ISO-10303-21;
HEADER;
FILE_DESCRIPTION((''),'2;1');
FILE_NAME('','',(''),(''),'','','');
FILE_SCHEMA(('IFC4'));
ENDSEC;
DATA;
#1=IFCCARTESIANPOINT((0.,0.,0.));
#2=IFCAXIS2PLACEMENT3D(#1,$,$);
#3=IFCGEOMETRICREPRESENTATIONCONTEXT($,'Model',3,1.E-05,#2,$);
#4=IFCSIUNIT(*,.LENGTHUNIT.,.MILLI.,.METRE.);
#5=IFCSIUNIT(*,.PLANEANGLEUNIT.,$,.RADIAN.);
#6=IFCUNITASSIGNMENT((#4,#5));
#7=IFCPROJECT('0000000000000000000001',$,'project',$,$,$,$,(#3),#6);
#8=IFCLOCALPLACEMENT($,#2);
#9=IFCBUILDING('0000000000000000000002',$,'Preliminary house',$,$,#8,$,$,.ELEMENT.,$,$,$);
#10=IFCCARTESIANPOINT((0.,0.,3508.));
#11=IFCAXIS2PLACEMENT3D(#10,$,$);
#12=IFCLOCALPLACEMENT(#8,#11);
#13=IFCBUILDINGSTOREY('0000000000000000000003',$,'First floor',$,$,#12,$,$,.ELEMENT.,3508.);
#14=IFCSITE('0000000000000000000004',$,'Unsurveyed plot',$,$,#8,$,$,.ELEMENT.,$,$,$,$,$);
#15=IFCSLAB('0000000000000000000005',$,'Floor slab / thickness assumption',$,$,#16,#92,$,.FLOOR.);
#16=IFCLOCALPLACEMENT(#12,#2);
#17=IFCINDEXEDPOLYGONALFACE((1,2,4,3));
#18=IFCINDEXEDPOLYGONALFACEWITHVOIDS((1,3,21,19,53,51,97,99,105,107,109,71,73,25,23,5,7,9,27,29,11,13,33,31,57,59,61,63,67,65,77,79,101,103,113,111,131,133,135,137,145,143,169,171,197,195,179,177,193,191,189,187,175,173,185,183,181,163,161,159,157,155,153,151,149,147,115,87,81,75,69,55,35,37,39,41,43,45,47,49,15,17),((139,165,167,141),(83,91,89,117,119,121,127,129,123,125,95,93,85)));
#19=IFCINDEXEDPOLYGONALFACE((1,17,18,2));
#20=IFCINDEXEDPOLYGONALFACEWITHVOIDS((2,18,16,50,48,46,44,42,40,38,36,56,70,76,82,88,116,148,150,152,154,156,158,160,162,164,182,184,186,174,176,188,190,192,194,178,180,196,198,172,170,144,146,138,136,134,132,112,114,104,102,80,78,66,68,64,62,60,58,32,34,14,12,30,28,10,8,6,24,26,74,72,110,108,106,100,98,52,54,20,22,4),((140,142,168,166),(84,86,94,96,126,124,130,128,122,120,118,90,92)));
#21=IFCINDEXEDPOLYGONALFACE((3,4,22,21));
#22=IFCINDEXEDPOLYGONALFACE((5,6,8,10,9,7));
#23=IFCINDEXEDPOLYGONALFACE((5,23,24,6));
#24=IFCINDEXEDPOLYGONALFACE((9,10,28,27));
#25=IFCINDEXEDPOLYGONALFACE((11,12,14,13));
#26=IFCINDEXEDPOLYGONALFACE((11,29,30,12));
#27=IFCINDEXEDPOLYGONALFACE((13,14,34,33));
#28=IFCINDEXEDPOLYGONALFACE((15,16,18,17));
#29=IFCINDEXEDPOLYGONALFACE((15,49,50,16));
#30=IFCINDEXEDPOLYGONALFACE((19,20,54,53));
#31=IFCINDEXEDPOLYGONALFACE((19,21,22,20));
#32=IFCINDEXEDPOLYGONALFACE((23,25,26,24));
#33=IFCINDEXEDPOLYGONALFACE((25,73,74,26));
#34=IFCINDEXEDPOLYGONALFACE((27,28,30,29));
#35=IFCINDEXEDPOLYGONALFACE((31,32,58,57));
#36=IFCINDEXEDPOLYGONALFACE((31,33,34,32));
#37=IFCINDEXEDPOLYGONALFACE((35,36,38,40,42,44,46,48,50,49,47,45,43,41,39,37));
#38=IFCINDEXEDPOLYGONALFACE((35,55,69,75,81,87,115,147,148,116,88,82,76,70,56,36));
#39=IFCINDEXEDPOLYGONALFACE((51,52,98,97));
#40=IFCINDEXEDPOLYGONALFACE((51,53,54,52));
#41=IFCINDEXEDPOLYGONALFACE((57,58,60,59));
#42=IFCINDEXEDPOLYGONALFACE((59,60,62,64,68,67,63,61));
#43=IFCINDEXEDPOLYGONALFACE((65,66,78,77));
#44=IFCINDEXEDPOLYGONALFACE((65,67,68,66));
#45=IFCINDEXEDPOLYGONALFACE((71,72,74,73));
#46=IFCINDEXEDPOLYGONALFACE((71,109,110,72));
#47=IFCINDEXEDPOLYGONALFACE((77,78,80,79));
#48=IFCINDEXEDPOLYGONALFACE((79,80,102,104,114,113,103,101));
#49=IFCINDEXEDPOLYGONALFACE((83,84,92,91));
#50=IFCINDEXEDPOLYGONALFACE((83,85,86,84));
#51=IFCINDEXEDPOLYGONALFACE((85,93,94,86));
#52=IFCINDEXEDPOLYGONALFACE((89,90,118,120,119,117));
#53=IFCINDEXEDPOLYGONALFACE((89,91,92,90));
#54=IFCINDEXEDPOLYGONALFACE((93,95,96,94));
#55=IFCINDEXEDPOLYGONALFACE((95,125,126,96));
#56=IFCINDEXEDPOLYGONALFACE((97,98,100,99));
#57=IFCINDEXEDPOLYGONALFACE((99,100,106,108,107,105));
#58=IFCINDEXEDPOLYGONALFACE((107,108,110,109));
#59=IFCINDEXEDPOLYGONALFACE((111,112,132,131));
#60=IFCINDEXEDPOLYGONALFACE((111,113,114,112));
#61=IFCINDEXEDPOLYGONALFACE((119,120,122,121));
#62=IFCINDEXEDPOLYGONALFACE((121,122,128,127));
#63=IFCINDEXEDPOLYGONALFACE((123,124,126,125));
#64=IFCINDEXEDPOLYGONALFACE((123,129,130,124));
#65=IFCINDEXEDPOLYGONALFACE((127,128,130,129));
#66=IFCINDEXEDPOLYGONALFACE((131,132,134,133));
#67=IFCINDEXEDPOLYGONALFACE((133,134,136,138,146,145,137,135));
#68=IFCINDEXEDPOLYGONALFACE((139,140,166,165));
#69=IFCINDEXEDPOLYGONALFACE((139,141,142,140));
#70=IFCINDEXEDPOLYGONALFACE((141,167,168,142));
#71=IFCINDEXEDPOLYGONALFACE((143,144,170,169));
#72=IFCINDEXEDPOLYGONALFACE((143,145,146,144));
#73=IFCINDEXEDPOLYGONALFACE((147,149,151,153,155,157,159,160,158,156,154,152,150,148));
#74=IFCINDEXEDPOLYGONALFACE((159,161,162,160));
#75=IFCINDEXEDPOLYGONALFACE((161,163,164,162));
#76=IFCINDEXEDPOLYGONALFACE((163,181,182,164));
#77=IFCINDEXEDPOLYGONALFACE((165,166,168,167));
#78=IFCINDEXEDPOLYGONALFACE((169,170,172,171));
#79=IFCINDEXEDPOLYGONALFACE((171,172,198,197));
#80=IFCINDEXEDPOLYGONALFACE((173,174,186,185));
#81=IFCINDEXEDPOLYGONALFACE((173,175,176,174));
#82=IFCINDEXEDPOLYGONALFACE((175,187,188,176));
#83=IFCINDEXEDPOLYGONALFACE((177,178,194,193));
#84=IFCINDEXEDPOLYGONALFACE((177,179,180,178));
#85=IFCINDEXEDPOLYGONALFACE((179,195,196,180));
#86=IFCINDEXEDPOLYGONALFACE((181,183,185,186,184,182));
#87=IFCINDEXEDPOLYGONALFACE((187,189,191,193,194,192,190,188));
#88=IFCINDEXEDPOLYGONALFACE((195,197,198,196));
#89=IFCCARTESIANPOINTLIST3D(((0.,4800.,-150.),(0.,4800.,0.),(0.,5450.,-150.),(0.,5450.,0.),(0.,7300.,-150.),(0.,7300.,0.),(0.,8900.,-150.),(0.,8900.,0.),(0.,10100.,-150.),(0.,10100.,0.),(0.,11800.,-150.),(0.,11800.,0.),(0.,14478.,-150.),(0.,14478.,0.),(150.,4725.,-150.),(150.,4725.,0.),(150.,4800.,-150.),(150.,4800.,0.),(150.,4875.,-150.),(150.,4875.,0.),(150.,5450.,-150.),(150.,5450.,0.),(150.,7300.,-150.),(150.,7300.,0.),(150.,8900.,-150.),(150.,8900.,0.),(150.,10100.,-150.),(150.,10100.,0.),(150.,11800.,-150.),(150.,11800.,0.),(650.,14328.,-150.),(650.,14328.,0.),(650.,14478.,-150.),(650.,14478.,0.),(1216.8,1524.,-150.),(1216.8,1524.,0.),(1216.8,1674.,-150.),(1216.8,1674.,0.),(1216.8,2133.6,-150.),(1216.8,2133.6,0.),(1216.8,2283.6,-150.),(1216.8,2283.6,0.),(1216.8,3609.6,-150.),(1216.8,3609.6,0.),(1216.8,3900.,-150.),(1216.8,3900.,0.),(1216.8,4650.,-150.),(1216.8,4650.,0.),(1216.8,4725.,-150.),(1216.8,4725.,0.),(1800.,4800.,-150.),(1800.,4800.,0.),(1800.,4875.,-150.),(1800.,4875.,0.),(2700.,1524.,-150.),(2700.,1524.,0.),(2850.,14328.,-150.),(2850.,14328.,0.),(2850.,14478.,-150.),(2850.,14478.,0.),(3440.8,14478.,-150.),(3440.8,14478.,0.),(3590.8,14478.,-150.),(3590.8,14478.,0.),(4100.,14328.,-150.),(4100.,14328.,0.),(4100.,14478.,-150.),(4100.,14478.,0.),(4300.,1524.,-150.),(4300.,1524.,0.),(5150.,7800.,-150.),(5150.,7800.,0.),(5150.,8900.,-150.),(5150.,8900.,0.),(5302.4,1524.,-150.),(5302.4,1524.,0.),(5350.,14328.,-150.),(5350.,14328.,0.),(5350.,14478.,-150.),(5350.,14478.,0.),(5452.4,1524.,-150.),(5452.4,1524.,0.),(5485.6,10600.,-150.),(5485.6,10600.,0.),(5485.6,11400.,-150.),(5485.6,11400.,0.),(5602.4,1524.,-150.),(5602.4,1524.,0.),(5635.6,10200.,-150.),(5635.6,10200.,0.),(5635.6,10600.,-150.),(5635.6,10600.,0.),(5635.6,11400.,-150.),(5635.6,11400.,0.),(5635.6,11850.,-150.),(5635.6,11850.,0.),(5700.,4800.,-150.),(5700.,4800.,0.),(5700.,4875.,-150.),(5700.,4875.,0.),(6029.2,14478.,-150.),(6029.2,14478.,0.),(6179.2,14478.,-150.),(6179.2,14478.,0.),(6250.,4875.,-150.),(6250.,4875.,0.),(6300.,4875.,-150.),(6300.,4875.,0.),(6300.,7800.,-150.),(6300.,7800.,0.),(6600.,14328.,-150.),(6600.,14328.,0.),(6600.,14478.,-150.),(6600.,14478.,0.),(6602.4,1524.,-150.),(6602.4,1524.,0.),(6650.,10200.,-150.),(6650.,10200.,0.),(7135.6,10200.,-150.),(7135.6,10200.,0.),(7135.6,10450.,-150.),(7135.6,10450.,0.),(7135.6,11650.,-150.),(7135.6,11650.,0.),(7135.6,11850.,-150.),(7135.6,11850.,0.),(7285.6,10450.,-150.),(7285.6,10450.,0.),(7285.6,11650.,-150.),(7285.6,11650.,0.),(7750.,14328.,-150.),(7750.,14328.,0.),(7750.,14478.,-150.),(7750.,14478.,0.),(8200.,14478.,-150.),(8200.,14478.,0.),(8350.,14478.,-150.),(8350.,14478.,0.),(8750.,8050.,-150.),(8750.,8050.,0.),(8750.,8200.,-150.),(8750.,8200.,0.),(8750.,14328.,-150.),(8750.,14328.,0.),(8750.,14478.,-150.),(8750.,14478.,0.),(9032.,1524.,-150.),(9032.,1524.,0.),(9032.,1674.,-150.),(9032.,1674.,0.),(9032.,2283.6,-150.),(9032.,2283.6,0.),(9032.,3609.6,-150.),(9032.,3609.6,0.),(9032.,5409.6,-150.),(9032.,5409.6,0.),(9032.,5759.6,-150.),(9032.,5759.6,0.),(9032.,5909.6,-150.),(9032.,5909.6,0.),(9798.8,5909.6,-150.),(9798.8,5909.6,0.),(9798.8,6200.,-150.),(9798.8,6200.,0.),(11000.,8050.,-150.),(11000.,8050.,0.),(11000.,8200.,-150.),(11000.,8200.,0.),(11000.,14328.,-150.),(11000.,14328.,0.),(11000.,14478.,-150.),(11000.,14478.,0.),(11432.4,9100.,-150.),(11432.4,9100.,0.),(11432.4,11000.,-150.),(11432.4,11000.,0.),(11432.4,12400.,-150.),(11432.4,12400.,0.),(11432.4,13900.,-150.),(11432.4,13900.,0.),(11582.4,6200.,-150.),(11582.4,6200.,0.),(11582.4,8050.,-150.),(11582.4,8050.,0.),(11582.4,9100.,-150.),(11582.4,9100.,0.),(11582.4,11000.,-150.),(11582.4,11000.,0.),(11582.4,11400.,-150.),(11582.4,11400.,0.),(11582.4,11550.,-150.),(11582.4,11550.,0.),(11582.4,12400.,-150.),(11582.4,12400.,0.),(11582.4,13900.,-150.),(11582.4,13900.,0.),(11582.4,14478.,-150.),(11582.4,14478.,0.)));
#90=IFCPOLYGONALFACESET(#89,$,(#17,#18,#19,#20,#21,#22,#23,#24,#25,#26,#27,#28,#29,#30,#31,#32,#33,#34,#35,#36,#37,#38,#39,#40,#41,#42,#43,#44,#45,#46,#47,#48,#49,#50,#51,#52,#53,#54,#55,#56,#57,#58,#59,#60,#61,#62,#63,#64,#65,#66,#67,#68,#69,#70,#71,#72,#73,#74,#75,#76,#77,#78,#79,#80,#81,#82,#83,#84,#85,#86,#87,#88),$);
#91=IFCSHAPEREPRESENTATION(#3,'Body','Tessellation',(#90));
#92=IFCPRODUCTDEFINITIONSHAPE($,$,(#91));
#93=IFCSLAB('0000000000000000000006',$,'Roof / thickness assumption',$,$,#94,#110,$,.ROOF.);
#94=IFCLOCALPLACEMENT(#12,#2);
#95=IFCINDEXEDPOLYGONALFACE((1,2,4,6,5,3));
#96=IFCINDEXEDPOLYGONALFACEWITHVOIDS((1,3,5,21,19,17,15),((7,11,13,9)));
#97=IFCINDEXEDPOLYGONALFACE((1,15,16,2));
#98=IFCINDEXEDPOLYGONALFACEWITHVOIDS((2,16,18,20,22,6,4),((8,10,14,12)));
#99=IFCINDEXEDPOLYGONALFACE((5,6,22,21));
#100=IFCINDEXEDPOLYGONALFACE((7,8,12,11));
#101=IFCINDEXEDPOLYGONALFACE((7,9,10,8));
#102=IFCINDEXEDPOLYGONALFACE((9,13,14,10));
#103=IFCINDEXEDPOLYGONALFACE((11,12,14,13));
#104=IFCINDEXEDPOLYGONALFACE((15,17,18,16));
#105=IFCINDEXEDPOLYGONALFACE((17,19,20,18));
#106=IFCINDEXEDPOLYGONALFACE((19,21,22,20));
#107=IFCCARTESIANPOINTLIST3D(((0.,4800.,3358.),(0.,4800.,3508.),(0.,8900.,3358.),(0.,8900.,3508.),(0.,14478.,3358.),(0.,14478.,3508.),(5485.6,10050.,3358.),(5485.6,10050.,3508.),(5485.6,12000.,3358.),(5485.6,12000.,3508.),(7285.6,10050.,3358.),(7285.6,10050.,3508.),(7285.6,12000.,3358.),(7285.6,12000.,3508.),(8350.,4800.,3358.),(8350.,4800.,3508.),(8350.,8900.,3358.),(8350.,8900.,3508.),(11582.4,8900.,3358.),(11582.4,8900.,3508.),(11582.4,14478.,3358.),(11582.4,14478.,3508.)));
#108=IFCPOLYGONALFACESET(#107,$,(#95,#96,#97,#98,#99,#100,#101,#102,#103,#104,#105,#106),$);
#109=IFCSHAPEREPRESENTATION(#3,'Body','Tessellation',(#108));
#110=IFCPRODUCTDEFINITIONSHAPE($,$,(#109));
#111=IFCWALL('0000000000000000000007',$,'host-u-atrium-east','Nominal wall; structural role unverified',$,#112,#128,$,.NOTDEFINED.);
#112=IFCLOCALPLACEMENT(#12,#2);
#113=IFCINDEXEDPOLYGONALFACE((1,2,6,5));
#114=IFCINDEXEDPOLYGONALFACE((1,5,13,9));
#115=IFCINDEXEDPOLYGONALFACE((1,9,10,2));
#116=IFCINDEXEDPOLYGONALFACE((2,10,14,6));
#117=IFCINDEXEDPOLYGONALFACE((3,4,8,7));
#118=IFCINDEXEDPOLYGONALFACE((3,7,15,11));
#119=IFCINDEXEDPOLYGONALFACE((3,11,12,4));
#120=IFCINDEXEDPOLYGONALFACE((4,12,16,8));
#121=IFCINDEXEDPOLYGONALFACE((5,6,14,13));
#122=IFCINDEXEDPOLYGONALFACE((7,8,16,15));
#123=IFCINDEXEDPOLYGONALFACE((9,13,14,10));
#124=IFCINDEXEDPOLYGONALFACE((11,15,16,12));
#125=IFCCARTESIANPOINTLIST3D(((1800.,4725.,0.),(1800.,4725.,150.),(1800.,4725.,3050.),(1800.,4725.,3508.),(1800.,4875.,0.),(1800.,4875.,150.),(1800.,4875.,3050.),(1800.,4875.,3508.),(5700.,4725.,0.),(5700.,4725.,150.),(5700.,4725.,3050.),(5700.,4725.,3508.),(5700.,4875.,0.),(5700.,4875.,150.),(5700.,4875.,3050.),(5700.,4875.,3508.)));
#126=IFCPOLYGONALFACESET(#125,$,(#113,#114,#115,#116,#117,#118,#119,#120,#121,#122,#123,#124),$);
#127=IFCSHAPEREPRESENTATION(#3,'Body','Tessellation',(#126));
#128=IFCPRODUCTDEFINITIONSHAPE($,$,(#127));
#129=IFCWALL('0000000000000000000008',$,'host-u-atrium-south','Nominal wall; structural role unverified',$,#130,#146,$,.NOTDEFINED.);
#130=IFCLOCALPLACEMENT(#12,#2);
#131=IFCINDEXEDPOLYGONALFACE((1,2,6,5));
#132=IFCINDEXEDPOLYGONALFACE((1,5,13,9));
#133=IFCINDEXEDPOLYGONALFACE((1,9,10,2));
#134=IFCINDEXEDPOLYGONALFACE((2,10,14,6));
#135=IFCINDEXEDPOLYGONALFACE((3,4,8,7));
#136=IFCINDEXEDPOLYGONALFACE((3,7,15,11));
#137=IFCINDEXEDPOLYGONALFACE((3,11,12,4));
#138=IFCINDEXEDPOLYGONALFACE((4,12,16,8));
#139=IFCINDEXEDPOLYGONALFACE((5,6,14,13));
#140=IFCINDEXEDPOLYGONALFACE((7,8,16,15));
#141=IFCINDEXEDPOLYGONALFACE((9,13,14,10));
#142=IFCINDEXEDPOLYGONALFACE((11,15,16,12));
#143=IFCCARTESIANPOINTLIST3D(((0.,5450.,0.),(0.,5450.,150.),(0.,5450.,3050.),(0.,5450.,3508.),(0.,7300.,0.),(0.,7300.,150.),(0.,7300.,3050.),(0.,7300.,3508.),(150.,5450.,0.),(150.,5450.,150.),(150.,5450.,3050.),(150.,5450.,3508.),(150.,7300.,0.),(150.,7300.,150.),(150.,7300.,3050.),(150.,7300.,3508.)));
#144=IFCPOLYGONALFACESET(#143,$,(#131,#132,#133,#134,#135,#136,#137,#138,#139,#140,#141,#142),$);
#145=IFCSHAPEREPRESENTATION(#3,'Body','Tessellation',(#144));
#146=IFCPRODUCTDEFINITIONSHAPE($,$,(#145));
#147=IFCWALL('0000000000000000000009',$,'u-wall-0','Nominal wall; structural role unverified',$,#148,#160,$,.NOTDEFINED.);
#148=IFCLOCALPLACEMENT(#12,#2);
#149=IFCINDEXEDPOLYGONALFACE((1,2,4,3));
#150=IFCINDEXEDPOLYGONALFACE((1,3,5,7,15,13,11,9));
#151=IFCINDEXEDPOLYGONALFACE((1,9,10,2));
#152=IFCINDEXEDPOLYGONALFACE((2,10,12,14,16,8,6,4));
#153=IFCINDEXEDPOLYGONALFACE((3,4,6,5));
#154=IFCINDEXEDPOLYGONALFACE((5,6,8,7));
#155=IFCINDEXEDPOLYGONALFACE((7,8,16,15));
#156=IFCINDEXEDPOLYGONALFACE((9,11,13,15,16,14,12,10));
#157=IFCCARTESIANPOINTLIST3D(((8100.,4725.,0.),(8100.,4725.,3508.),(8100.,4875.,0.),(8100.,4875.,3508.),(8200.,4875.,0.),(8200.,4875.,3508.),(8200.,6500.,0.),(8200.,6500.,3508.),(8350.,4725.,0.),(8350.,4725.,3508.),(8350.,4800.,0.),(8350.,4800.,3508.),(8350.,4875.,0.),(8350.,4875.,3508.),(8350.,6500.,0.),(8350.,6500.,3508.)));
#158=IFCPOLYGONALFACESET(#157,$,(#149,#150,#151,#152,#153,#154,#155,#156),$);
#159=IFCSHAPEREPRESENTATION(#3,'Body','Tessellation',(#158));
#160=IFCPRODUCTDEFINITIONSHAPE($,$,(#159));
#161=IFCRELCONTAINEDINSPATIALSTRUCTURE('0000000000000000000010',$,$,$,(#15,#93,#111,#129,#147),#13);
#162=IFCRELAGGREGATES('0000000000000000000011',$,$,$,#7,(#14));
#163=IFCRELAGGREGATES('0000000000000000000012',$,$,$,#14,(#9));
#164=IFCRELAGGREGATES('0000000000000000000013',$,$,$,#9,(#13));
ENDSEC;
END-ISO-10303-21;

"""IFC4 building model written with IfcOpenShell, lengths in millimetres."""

from ifc_helpers import new_model, si_unit, frame, origin, place, context, project, spatial, polyline, outline, extrude, element, save


model = new_model("IFC4")

# Units and contexts
model_context = context("Model", 3, precision=1e-05, world=origin())
ifc_project = project(units=[si_unit("LENGTHUNIT", "METRE", prefix="MILLI"), si_unit("PLANEANGLEUNIT", "RADIAN")], contexts=[model_context])

# Site, building, storey
placement_1 = place(None, origin())
site = spatial("IfcSite", under=ifc_project, at=placement_1, Name="Unsurveyed plot", CompositionType="ELEMENT")
building = spatial("IfcBuilding", under=site, at=placement_1, Name="Preliminary house", CompositionType="ELEMENT")
placement_2 = place(placement_1, frame((0.0, 0.0, 3508.0)))
storey = spatial("IfcBuildingStorey", under=building, at=placement_2, Name="First floor", CompositionType="ELEMENT", Elevation=3508.0)

# Slabs
element("IfcSlab", 1, at=placement_2, inside=storey, Name="Floor slab / thickness assumption", PredefinedType="FLOOR", context=model_context, shape_type="SweptSolid", body=[
    extrude(outline(polyline([(6300.0, 4875.0), (6300.0, 7800.0), (5150.0, 7800.0), (5150.0, 8900.0), (150.0, 8900.0), (150.0, 7300.0), (0.0, 7300.0), (0.0, 8900.0), (0.0, 10100.0), (150.0, 10100.0), (150.0, 11800.0), (0.0, 11800.0), (0.0, 14478.0), (650.0, 14478.0), (650.0, 14328.0), (2850.0, 14328.0), (2850.0, 14478.0), (3440.8, 14478.0), (3590.8, 14478.0), (4100.0, 14478.0), (4100.0, 14328.0), (5350.0, 14328.0), (5350.0, 14478.0), (6029.2, 14478.0), (6179.2, 14478.0), (6600.0, 14478.0), (6600.0, 14328.0), (7750.0, 14328.0), (7750.0, 14478.0), (8200.0, 14478.0), (8350.0, 14478.0), (8750.0, 14478.0), (8750.0, 14328.0), (11000.0, 14328.0), (11000.0, 14478.0), (11582.4, 14478.0), (11582.4, 13900.0), (11432.4, 13900.0), (11432.4, 12400.0), (11582.4, 12400.0), (11582.4, 11550.0), (11582.4, 11400.0), (11582.4, 11000.0), (11432.4, 11000.0), (11432.4, 9100.0), (11582.4, 9100.0), (11582.4, 8050.0), (11582.4, 6200.0), (9798.8, 6200.0), (9798.8, 5909.6), (9032.0, 5909.6), (9032.0, 5759.6), (9032.0, 5409.6), (9032.0, 3609.6), (9032.0, 2283.6), (9032.0, 1674.0), (9032.0, 1524.0), (6602.4, 1524.0), (5602.4, 1524.0), (5452.4, 1524.0), (5302.4, 1524.0), (4300.0, 1524.0), (2700.0, 1524.0), (1216.8, 1524.0), (1216.8, 1674.0), (1216.8, 2133.6), (1216.8, 2283.6), (1216.8, 3609.6), (1216.8, 3900.0), (1216.8, 4650.0), (1216.8, 4725.0), (150.0, 4725.0), (150.0, 4800.0), (0.0, 4800.0), (0.0, 5450.0), (150.0, 5450.0), (150.0, 4875.0), (1800.0, 4875.0), (1800.0, 4800.0), (5700.0, 4800.0), (5700.0, 4875.0), (6250.0, 4875.0), (6300.0, 4875.0)]), holes=[polyline([(11000.0, 8050.0), (11000.0, 8200.0), (8750.0, 8200.0), (8750.0, 8050.0), (11000.0, 8050.0)]), polyline([(7135.6, 11650.0), (7135.6, 11850.0), (5635.6, 11850.0), (5635.6, 11400.0), (5485.6, 11400.0), (5485.6, 10600.0), (5635.6, 10600.0), (5635.6, 10200.0), (6650.0, 10200.0), (7135.6, 10200.0), (7135.6, 10450.0), (7285.6, 10450.0), (7285.6, 11650.0), (7135.6, 11650.0)])]), frame((0.0, 0.0, -150.0)), (0.0, 0.0, 1.0), 150.0),
])
element("IfcSlab", 2, at=placement_2, inside=storey, Name="Roof / thickness assumption", PredefinedType="ROOF", context=model_context, shape_type="SweptSolid", body=[
    extrude(outline(polyline([(0.0, 4800.0), (0.0, 8900.0), (0.0, 14478.0), (11582.4, 14478.0), (11582.4, 8900.0), (8350.0, 8900.0), (8350.0, 4800.0), (0.0, 4800.0)]), holes=[polyline([(7285.6, 12000.0), (5485.6, 12000.0), (5485.6, 10050.0), (7285.6, 10050.0), (7285.6, 12000.0)])]), frame((0.0, 0.0, 3358.0)), (0.0, 0.0, 1.0), 150.0),
])

# Walls, openings
wall_1 = element("IfcWall", 3, at=placement_2, inside=storey, Name="host-u-atrium-east", Description="Nominal wall; structural role unverified", PredefinedType="NOTDEFINED", context=model_context, shape_type="SweptSolid", body=[
    extrude(outline(polyline([(5700.0, 4875.0), (5700.0, 4725.0), (1800.0, 4725.0), (1800.0, 4875.0), (5700.0, 4875.0)])), origin(), (0.0, 0.0, 1.0), 3508.0),
])
element("IfcOpeningElement", 4, at=placement_2, cuts=wall_1, PredefinedType="OPENING", context=model_context, shape_type="SweptSolid", body=[
    extrude(outline(polyline([(1800.0, 4350.0), (5700.0, 4350.0), (5700.0, 5250.0), (1800.0, 5250.0), (1800.0, 4350.0)])), frame((0.0, 0.0, 150.0)), (0.0, 0.0, 1.0), 2900.0),
])
wall_2 = element("IfcWall", 5, at=placement_2, inside=storey, Name="host-u-atrium-south", Description="Nominal wall; structural role unverified", PredefinedType="NOTDEFINED", context=model_context, shape_type="SweptSolid", body=[
    extrude(outline(polyline([(0.0, 7300.0), (150.0, 7300.0), (150.0, 5450.0), (0.0, 5450.0), (0.0, 7300.0)])), origin(), (0.0, 0.0, 1.0), 3508.0),
])
element("IfcOpeningElement", 6, at=placement_2, cuts=wall_2, PredefinedType="OPENING", context=model_context, shape_type="SweptSolid", body=[
    extrude(outline(polyline([(525.0, 5450.0), (525.0, 7300.0), (-375.0, 7300.0), (-375.0, 5450.0), (525.0, 5450.0)])), frame((0.0, 0.0, 150.0)), (0.0, 0.0, 1.0), 2900.0),
])

# Wall
element("IfcWall", 7, at=placement_2, inside=storey, Name="u-wall-0", Description="Nominal wall; structural role unverified", PredefinedType="NOTDEFINED", context=model_context, shape_type="SweptSolid", body=[
    extrude(outline(polyline([(8350.0, 4875.0), (8350.0, 4800.0), (8350.0, 4725.0), (8100.0, 4725.0), (8100.0, 4875.0), (8200.0, 4875.0), (8200.0, 6500.0), (8350.0, 6500.0), (8350.0, 4875.0)])), origin(), (0.0, 0.0, 1.0), 3508.0),
])

save(model, "model.ifc")
